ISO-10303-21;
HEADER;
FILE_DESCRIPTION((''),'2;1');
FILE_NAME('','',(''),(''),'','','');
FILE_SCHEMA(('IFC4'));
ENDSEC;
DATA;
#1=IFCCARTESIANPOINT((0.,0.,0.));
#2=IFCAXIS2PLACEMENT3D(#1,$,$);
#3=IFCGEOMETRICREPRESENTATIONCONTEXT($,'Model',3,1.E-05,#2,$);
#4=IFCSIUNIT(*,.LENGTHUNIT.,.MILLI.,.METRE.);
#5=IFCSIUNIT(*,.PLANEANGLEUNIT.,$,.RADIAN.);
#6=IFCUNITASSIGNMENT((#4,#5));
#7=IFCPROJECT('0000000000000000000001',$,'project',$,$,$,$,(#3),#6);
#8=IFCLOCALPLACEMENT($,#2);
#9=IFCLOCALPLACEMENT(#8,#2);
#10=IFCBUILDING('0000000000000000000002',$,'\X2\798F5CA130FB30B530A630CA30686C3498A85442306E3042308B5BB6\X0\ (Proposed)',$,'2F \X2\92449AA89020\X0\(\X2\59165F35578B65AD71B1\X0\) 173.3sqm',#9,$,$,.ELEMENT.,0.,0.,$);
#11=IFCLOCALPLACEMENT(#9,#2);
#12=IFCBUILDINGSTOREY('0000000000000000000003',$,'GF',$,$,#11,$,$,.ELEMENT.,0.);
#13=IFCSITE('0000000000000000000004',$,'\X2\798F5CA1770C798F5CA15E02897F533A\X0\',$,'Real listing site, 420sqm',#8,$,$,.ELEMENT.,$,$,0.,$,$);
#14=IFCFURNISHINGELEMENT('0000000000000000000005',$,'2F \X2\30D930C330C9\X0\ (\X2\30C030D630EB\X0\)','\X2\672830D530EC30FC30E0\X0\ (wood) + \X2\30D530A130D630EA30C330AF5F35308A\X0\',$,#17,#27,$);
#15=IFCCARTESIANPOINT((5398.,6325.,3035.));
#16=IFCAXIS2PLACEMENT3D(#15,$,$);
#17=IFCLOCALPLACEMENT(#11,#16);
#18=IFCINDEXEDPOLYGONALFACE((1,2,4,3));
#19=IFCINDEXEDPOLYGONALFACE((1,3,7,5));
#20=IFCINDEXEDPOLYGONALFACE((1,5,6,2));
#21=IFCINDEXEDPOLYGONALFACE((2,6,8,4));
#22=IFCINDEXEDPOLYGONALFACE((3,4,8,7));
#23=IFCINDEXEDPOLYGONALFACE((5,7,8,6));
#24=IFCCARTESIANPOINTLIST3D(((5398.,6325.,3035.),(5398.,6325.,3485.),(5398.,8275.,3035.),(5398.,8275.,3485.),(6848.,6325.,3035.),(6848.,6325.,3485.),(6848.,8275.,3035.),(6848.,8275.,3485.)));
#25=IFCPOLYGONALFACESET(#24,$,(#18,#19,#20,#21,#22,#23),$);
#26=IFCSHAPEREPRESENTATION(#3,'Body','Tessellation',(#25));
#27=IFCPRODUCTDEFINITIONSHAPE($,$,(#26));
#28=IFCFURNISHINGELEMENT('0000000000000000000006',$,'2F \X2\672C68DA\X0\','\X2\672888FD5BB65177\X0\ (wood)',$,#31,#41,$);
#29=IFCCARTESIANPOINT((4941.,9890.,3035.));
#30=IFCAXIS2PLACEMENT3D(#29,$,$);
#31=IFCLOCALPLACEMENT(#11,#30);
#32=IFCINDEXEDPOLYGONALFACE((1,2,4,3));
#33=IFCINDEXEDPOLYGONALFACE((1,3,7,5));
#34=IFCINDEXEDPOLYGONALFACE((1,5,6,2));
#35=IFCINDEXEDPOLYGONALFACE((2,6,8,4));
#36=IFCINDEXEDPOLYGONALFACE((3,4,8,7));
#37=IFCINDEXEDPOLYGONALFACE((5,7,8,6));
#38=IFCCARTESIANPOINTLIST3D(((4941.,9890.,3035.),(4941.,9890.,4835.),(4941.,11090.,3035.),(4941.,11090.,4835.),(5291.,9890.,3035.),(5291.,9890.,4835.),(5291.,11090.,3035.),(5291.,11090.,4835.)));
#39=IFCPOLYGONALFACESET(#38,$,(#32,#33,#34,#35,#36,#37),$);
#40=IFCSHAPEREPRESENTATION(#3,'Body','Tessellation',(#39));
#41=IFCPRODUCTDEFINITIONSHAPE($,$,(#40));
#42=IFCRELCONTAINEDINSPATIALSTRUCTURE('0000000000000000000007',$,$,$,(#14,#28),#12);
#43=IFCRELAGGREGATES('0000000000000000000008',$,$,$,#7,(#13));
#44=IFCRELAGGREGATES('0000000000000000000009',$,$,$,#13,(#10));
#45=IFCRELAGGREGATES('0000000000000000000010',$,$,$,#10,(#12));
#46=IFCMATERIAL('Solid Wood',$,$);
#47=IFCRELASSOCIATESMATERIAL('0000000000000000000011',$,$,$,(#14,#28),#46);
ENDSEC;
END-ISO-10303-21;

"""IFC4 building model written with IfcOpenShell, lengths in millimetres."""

from ifc_helpers import new_model, si_unit, frame, frame_2d, origin, place, context, project, spatial, rectangle, extrude, material, element, save


model = new_model("IFC4")

# Units and contexts
model_context = context("Model", 3, precision=1e-05, world=origin())
ifc_project = project(units=[si_unit("LENGTHUNIT", "METRE", prefix="MILLI"), si_unit("PLANEANGLEUNIT", "RADIAN")], contexts=[model_context])

# Site, building, storey
site_placement = place(None, origin())
site = spatial("IfcSite", under=ifc_project, at=site_placement, Name="福岡県福岡市西区", ObjectType="Real listing site, 420sqm", CompositionType="ELEMENT", RefElevation=0.0)
building_placement = place(site_placement, origin())
building = spatial("IfcBuilding", under=site, at=building_placement, Name="福岡・サウナと水風呂のある家 (Proposed)", ObjectType="2F 鉄骨造(外張型断熱) 173.3sqm", CompositionType="ELEMENT", ElevationOfRefHeight=0.0, ElevationOfTerrain=0.0)
storey_placement = place(building_placement, origin())
storey = spatial("IfcBuildingStorey", under=building, at=storey_placement, Name="GF", CompositionType="ELEMENT", Elevation=0.0)

# Shared definitions
ifc_material_1 = material(Name="Solid Wood")

# Furnishing elements
furnishing_1_placement = place(storey_placement, frame((5398.0, 6325.0, 3035.0)))
element("IfcFurnishingElement", 1, at=furnishing_1_placement, inside=storey, material=ifc_material_1, Name="2F ベッド (ダブル)", Description="木フレーム (wood) + ファブリック張り", context=model_context, shape_type="SweptSolid", body=[
    extrude(rectangle(XDim=1450.0, YDim=1950.0, at=frame_2d((725.0, 975.0))), frame((5398.0, 6325.0, 3035.0)), (0.0, 0.0, 1.0), 450.0),
])
furnishing_2_placement = place(storey_placement, frame((4941.0, 9890.0, 3035.0)))
element("IfcFurnishingElement", 2, at=furnishing_2_placement, inside=storey, material=ifc_material_1, Name="2F 本棚", Description="木製家具 (wood)", context=model_context, shape_type="SweptSolid", body=[
    extrude(rectangle(XDim=350.0, YDim=1200.0, at=frame_2d((175.0, 600.0))), frame((4941.0, 9890.0, 3035.0)), (0.0, 0.0, 1.0), 1800.0),
])

save(model, "model.ifc")
